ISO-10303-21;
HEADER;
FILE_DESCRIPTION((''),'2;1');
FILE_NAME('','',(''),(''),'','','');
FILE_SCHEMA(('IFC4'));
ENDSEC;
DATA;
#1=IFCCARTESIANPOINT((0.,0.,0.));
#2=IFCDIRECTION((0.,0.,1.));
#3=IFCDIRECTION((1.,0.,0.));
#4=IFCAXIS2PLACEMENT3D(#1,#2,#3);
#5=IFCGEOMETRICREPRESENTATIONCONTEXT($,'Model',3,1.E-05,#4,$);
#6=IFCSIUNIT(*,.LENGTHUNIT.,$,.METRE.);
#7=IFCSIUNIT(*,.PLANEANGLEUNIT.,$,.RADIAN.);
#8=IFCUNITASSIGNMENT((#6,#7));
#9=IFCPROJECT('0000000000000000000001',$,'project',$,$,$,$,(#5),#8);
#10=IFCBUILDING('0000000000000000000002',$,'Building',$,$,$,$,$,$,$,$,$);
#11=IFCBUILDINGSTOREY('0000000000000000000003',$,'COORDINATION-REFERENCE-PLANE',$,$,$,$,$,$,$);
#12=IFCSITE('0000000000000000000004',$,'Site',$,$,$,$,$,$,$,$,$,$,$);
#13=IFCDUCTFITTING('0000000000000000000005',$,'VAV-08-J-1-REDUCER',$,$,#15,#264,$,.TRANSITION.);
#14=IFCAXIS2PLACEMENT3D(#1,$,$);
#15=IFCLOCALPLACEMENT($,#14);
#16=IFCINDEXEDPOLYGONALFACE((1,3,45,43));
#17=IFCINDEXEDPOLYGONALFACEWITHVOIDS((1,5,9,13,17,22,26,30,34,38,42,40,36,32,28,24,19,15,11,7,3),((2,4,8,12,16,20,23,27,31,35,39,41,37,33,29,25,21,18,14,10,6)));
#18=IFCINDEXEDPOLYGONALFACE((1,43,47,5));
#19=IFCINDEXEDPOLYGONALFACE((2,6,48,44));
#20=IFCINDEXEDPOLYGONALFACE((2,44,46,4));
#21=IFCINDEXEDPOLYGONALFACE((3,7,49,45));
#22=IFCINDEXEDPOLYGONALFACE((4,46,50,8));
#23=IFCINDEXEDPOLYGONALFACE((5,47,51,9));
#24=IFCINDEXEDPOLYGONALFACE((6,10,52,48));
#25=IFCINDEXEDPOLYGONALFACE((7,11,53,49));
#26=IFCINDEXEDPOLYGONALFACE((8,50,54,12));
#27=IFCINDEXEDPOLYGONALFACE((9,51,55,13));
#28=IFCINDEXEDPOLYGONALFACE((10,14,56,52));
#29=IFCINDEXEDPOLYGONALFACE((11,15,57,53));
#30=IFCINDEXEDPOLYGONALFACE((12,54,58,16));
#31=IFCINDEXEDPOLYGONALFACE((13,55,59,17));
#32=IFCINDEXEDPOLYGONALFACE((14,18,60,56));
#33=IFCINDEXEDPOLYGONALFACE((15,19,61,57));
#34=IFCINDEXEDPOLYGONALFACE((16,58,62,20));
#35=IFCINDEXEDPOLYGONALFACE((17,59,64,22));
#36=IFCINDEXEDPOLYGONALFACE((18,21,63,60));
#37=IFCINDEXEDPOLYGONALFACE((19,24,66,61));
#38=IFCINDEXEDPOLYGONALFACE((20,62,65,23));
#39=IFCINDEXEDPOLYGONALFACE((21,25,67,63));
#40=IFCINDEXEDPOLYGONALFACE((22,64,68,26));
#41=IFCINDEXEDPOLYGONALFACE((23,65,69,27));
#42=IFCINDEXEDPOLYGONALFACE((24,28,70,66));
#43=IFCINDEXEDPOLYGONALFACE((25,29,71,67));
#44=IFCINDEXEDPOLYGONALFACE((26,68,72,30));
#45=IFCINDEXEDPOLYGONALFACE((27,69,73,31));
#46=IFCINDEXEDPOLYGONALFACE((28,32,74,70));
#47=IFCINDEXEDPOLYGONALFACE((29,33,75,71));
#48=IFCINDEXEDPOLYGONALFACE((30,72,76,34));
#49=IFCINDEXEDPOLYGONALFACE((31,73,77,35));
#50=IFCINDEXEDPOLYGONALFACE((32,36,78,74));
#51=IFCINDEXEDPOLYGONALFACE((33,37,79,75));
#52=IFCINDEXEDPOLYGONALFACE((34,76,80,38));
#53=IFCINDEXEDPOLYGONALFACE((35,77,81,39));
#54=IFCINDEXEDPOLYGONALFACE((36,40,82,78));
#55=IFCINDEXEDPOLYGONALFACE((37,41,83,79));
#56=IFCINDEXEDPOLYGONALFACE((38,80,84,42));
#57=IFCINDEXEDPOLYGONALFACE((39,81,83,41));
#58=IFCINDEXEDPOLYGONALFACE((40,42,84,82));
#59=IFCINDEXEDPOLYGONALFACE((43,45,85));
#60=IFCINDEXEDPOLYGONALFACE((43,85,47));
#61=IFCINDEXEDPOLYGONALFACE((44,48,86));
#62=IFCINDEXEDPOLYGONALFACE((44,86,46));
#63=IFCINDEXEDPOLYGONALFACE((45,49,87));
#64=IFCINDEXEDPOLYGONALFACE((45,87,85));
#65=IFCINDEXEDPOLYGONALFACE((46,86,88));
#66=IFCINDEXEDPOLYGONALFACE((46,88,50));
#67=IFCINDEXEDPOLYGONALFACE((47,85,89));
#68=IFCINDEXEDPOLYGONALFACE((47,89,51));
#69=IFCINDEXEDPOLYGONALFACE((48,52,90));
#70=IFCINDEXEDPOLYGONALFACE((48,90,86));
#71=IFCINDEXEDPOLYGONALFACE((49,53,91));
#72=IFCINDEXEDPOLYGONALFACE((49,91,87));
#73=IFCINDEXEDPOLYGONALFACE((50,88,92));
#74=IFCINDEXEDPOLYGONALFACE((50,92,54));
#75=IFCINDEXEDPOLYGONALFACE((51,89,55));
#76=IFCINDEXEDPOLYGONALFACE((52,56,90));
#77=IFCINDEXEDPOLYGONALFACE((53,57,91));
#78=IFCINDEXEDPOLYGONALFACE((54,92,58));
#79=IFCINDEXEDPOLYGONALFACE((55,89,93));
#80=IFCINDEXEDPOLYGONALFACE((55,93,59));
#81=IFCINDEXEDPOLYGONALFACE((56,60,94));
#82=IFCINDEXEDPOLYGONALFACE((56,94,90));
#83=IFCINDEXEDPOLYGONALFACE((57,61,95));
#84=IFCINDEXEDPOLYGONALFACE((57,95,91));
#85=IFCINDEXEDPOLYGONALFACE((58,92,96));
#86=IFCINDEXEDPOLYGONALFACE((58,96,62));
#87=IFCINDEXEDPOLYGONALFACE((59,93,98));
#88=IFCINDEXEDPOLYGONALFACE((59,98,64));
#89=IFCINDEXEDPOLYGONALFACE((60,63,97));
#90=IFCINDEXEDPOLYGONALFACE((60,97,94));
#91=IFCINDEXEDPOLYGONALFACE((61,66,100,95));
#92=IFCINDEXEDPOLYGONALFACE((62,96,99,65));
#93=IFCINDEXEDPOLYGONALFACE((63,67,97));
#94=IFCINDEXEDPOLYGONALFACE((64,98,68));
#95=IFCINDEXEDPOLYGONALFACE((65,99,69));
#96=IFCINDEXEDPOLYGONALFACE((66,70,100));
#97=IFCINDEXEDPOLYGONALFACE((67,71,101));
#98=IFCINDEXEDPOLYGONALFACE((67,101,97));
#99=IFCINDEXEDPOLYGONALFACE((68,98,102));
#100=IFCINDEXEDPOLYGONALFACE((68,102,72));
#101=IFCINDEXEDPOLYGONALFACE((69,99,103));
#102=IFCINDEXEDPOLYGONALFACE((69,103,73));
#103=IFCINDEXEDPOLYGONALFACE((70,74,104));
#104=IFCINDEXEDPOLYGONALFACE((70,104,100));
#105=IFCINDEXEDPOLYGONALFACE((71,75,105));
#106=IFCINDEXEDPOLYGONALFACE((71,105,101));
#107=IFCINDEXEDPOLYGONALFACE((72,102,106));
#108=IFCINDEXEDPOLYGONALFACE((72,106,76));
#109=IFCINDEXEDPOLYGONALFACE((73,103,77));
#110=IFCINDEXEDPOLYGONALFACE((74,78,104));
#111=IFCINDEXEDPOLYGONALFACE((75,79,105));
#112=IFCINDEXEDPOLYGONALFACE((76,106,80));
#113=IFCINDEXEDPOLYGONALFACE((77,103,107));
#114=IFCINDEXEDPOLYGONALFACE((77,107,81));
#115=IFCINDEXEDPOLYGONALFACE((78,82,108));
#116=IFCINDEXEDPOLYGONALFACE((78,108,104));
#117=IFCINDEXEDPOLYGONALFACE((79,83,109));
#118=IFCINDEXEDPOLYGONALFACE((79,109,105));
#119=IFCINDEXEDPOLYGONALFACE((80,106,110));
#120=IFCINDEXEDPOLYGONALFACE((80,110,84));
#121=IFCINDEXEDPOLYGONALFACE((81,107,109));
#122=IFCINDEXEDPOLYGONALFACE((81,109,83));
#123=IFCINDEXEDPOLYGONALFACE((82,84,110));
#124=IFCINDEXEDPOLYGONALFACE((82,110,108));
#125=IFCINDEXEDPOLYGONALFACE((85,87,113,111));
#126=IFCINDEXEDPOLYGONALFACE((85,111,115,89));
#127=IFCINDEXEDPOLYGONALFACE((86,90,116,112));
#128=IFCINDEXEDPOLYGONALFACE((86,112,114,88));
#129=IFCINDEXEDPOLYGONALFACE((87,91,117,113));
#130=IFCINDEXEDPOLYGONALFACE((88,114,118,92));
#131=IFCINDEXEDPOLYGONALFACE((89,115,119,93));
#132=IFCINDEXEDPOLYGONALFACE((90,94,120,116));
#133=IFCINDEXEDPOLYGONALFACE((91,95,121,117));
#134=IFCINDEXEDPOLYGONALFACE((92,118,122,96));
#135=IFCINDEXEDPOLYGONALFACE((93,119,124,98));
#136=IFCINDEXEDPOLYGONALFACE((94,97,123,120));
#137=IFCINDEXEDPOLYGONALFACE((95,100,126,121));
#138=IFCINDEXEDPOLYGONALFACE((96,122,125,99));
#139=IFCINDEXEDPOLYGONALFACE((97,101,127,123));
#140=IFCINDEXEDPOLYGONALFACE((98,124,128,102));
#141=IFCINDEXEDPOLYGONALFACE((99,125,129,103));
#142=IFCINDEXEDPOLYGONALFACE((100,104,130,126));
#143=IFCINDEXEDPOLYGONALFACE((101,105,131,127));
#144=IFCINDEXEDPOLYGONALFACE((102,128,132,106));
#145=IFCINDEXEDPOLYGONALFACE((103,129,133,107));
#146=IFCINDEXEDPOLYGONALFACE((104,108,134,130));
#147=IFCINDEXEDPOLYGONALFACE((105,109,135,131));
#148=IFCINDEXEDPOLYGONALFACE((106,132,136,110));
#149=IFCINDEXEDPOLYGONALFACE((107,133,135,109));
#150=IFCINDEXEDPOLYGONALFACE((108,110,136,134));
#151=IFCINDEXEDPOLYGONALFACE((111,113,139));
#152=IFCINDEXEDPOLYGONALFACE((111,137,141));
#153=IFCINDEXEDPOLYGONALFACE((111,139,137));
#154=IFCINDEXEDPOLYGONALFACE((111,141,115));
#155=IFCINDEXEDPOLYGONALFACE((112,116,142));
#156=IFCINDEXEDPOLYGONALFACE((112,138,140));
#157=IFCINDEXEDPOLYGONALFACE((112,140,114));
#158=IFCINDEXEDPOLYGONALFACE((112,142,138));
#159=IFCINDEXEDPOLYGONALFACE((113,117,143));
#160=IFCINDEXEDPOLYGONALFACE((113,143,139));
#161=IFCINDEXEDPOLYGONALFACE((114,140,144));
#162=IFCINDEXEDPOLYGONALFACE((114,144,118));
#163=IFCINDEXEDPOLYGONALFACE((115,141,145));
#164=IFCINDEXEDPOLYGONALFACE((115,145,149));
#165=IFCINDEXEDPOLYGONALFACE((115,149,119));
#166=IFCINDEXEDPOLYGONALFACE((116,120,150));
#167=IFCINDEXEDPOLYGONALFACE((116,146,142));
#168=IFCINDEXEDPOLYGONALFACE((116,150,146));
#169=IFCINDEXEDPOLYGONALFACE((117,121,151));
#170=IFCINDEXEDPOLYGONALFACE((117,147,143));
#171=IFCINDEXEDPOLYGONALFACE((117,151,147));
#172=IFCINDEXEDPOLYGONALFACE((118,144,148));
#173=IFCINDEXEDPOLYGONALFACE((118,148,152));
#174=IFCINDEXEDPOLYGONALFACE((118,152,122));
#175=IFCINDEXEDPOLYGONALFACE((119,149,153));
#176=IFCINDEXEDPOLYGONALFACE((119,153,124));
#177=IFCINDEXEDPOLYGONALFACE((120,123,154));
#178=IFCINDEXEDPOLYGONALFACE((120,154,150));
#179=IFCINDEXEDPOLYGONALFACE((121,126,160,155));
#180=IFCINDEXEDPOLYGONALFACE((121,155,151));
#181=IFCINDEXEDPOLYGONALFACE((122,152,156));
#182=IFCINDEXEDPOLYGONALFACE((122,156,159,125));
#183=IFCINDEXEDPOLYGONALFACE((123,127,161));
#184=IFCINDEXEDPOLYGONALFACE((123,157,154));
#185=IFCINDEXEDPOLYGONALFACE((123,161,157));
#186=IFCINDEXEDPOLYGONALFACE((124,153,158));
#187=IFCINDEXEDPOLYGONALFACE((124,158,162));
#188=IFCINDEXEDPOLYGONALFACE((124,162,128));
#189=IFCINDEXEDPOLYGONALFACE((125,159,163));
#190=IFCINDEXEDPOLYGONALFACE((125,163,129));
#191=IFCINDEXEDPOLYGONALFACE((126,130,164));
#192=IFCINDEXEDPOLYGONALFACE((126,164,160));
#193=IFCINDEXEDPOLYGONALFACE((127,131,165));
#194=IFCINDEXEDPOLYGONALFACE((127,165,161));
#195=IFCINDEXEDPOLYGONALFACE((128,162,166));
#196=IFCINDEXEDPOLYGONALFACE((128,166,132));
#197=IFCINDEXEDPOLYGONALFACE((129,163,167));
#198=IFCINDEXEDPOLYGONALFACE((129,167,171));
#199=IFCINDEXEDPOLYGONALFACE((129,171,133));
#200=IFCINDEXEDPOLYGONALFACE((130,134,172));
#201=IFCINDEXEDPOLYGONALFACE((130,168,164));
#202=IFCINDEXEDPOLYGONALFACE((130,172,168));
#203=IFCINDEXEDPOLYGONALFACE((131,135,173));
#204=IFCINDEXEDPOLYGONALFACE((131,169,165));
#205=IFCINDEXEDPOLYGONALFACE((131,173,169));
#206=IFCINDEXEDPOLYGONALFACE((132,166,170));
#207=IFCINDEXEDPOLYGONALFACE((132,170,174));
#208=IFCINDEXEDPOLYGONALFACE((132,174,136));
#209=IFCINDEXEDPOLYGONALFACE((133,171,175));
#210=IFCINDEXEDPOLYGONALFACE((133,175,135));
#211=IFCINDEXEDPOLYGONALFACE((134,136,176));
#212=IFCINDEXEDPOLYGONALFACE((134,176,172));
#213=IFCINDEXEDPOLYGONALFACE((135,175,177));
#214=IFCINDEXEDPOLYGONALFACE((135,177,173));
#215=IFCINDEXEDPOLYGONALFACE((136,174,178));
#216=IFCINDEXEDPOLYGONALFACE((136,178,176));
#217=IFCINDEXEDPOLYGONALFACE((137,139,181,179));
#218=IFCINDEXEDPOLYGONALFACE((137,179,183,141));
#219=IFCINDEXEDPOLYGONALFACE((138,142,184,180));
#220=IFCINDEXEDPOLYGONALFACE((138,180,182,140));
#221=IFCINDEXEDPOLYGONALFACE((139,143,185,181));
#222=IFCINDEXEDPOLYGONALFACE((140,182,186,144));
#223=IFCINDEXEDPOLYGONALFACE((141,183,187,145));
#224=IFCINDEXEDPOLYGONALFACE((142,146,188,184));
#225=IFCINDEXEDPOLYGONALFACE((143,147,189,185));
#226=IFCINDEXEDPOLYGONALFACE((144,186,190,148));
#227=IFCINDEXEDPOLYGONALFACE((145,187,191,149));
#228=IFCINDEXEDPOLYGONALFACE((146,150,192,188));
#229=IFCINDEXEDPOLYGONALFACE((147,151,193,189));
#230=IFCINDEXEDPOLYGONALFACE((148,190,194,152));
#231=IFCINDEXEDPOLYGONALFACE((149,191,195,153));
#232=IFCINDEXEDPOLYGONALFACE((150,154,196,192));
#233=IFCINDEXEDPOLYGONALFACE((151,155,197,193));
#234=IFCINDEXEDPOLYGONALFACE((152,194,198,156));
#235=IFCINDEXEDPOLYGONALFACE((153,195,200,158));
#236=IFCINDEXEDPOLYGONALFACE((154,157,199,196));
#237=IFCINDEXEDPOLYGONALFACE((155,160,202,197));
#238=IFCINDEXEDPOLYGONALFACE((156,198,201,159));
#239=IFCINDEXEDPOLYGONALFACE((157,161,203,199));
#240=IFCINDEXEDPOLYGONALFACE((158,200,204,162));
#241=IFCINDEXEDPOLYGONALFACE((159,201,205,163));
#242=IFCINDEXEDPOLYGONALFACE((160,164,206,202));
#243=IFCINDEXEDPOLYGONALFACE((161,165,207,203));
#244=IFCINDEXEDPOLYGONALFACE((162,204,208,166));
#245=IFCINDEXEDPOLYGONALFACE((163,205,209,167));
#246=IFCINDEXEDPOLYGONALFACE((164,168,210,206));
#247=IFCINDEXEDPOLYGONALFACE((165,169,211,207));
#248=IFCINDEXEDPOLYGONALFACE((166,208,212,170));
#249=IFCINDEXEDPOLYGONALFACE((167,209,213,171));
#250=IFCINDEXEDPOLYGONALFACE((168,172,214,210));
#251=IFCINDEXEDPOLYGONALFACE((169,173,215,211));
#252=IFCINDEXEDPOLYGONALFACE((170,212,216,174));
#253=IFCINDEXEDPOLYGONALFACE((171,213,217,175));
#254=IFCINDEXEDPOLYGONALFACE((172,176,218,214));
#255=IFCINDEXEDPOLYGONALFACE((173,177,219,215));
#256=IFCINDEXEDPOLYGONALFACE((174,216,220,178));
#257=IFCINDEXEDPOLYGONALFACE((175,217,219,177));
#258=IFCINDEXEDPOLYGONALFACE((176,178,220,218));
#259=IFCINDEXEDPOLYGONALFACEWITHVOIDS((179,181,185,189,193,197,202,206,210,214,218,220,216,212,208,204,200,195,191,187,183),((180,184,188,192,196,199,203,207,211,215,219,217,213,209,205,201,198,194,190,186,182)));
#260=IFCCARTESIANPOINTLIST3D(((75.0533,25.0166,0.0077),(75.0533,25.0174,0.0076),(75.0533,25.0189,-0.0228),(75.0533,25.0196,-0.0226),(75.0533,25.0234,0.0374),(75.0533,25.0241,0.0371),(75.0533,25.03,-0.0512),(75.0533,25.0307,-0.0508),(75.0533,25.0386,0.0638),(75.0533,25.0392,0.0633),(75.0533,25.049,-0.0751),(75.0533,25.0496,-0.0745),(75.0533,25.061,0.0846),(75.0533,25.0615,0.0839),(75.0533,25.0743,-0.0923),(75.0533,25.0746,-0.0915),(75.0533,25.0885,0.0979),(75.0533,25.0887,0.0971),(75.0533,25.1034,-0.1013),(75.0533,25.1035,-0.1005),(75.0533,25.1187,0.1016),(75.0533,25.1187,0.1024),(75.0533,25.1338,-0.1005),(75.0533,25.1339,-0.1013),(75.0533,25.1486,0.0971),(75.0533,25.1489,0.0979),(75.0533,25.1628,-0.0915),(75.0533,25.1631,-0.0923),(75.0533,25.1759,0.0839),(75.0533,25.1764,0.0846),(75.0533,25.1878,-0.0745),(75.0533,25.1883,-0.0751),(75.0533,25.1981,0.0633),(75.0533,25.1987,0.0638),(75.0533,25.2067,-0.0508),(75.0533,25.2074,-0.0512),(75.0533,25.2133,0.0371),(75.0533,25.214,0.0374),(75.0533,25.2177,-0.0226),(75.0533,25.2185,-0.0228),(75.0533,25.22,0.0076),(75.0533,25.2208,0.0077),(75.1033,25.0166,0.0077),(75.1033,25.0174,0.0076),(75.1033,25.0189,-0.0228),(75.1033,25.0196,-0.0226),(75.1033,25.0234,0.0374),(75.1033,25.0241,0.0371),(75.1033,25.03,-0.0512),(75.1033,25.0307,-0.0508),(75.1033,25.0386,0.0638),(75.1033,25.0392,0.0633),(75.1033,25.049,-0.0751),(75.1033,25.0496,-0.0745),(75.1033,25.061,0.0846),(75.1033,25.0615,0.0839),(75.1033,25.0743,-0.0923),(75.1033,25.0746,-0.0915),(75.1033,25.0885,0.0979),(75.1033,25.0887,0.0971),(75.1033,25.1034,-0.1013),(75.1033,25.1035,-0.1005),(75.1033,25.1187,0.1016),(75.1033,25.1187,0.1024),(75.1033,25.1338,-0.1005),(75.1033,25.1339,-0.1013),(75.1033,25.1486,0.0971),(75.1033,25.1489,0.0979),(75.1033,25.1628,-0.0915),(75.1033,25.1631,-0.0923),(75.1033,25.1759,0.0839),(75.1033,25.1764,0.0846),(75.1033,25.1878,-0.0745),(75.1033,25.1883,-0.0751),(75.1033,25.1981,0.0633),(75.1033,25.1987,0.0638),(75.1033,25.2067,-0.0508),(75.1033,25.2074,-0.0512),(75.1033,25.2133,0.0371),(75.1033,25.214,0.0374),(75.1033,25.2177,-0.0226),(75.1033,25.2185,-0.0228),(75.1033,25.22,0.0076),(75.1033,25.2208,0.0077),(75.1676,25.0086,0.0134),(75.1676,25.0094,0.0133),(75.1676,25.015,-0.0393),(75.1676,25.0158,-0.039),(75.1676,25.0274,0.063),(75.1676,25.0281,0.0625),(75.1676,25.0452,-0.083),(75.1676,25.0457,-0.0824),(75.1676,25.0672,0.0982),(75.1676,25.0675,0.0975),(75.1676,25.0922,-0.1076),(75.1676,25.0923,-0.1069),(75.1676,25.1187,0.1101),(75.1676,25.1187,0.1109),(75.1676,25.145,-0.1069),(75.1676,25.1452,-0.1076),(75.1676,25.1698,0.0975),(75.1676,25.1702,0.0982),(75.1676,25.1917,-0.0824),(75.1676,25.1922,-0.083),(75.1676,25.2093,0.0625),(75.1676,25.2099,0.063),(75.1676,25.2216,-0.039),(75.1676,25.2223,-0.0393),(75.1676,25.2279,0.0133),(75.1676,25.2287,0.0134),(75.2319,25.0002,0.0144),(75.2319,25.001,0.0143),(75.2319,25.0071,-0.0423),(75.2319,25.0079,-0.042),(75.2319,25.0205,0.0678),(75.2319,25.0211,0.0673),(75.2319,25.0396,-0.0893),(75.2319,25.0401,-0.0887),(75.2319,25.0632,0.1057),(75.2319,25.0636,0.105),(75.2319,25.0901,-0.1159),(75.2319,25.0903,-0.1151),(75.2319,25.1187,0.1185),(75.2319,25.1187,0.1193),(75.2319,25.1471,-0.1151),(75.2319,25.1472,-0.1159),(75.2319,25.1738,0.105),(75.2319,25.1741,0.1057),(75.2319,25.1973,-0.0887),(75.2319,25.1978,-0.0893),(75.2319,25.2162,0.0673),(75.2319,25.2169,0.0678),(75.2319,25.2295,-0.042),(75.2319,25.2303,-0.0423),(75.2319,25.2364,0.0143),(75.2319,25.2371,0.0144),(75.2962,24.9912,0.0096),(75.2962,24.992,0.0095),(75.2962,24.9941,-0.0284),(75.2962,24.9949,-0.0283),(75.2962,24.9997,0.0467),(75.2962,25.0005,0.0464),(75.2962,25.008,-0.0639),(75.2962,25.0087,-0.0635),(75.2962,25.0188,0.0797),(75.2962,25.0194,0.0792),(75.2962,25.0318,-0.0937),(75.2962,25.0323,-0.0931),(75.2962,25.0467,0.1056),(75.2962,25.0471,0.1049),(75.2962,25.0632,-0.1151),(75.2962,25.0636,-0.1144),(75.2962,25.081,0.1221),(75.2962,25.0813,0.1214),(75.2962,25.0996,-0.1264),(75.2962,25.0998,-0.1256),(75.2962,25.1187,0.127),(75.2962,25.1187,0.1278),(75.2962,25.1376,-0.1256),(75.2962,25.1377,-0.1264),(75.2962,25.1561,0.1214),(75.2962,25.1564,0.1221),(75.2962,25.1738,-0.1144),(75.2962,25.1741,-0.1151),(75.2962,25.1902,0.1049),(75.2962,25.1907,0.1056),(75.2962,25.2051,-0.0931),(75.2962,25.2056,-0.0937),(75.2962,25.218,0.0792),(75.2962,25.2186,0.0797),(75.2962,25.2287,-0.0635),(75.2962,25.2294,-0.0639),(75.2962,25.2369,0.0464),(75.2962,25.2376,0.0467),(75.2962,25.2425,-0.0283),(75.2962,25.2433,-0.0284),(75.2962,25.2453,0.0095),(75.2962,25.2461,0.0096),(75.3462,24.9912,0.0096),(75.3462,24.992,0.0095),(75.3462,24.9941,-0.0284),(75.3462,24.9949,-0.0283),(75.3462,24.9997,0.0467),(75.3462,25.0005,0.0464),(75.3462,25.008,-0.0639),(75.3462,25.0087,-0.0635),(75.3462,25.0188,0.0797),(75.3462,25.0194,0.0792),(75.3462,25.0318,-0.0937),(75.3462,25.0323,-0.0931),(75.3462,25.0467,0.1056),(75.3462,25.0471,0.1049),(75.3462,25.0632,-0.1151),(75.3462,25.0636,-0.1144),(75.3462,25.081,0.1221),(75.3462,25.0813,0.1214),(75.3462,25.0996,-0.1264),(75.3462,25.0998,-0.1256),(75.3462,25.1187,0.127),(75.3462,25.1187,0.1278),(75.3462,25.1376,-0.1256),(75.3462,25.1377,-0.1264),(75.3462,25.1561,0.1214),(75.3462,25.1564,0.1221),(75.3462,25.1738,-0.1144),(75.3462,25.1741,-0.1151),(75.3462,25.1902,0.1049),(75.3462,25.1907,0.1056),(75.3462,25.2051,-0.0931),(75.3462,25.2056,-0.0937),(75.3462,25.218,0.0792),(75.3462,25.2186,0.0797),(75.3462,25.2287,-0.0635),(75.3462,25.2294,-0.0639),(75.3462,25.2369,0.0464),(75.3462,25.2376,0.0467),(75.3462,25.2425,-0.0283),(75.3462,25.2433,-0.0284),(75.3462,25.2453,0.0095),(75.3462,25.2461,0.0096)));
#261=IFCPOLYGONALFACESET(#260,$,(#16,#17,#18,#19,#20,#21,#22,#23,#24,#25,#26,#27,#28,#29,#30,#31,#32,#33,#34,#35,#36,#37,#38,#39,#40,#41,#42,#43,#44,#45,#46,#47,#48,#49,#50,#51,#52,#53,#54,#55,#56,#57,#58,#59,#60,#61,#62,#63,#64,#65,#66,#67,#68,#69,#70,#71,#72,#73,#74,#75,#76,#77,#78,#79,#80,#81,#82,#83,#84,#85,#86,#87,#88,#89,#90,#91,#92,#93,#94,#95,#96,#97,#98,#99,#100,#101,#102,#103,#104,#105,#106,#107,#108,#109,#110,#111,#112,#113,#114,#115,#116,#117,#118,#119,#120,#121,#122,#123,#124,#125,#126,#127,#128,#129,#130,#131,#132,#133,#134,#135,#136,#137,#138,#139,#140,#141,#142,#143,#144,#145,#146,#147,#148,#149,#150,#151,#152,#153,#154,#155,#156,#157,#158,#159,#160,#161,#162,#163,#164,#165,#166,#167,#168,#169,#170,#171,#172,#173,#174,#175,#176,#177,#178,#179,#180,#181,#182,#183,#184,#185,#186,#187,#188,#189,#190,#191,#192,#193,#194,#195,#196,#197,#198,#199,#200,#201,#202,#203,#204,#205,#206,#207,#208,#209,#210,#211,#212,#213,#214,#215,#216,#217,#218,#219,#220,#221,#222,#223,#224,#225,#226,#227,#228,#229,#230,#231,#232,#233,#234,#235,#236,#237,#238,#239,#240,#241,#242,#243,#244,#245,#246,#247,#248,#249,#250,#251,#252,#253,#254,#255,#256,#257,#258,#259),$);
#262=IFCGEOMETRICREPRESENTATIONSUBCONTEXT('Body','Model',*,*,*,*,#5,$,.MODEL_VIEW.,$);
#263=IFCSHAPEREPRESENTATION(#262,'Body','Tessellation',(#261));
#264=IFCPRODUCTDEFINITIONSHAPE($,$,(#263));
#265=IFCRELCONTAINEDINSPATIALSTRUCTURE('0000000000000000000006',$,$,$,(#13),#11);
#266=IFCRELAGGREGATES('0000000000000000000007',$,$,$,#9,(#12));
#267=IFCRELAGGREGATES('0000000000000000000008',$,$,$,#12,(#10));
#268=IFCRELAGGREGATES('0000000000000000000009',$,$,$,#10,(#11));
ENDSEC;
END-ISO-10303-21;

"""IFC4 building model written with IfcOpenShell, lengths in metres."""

from ifc_helpers import new_model, entity, si_unit, frame, origin_with_axes, place, context, subcontext, project, spatial, element, save


model = new_model("IFC4")

# Units and contexts
model_context_1 = context("Model", 3, precision=1e-05, world=origin_with_axes())
body_context_1 = subcontext(model_context_1, "Body", "Model", "MODEL_VIEW")
ifc_project = project(units=[si_unit("LENGTHUNIT", "METRE"), si_unit("PLANEANGLEUNIT", "RADIAN")], contexts=[model_context_1])

# Site, building, storey
site = spatial("IfcSite", under=ifc_project, Name="Site")
building = spatial("IfcBuilding", under=site, Name="Building")
storey = spatial("IfcBuildingStorey", under=building, Name="COORDINATION-REFERENCE-PLANE")

# Duct fitting
for number, where, z_axis, x_axis, name in (
    (1, (75.3462, 25.1187, 0.0), (0.0, -1.0, 0.0), (0.0, 0.0, 1.0), "VAV-08-J-1-REDUCER"),
):
    element("IfcDuctFitting", number, at=place(None, frame(where, z_axis=z_axis, x_axis=x_axis)), inside=storey, Name=name, PredefinedType="TRANSITION", context=body_context_1, shape_type="SweptSolid", body=[
        entity("IfcRevolvedAreaSolid", entity("IfcArbitraryClosedProfileDef", "AREA", None, entity("IfcPolyline", [entity("IfcCartesianPoint", [0.1278, 0.0]), entity("IfcCartesianPoint", [0.1278, 0.05]), entity("IfcCartesianPoint", [0.1024, 0.2429]), entity("IfcCartesianPoint", [0.1024, 0.2929]), entity("IfcCartesianPoint", [0.1016, 0.2929]), entity("IfcCartesianPoint", [0.1016, 0.2429]), entity("IfcCartesianPoint", [0.127, 0.05]), entity("IfcCartesianPoint", [0.127, 0.0]), entity("IfcCartesianPoint", [0.1278, 0.0])])), entity("IfcAxis2Placement3D", entity("IfcCartesianPoint", [0.0, 0.0, 0.0])), entity("IfcAxis1Placement", entity("IfcCartesianPoint", [0.0, 0.0, 0.0]), entity("IfcDirection", [0.0, 1.0, 0.0])), 6.283185),
    ])

save(model, "model.ifc")
